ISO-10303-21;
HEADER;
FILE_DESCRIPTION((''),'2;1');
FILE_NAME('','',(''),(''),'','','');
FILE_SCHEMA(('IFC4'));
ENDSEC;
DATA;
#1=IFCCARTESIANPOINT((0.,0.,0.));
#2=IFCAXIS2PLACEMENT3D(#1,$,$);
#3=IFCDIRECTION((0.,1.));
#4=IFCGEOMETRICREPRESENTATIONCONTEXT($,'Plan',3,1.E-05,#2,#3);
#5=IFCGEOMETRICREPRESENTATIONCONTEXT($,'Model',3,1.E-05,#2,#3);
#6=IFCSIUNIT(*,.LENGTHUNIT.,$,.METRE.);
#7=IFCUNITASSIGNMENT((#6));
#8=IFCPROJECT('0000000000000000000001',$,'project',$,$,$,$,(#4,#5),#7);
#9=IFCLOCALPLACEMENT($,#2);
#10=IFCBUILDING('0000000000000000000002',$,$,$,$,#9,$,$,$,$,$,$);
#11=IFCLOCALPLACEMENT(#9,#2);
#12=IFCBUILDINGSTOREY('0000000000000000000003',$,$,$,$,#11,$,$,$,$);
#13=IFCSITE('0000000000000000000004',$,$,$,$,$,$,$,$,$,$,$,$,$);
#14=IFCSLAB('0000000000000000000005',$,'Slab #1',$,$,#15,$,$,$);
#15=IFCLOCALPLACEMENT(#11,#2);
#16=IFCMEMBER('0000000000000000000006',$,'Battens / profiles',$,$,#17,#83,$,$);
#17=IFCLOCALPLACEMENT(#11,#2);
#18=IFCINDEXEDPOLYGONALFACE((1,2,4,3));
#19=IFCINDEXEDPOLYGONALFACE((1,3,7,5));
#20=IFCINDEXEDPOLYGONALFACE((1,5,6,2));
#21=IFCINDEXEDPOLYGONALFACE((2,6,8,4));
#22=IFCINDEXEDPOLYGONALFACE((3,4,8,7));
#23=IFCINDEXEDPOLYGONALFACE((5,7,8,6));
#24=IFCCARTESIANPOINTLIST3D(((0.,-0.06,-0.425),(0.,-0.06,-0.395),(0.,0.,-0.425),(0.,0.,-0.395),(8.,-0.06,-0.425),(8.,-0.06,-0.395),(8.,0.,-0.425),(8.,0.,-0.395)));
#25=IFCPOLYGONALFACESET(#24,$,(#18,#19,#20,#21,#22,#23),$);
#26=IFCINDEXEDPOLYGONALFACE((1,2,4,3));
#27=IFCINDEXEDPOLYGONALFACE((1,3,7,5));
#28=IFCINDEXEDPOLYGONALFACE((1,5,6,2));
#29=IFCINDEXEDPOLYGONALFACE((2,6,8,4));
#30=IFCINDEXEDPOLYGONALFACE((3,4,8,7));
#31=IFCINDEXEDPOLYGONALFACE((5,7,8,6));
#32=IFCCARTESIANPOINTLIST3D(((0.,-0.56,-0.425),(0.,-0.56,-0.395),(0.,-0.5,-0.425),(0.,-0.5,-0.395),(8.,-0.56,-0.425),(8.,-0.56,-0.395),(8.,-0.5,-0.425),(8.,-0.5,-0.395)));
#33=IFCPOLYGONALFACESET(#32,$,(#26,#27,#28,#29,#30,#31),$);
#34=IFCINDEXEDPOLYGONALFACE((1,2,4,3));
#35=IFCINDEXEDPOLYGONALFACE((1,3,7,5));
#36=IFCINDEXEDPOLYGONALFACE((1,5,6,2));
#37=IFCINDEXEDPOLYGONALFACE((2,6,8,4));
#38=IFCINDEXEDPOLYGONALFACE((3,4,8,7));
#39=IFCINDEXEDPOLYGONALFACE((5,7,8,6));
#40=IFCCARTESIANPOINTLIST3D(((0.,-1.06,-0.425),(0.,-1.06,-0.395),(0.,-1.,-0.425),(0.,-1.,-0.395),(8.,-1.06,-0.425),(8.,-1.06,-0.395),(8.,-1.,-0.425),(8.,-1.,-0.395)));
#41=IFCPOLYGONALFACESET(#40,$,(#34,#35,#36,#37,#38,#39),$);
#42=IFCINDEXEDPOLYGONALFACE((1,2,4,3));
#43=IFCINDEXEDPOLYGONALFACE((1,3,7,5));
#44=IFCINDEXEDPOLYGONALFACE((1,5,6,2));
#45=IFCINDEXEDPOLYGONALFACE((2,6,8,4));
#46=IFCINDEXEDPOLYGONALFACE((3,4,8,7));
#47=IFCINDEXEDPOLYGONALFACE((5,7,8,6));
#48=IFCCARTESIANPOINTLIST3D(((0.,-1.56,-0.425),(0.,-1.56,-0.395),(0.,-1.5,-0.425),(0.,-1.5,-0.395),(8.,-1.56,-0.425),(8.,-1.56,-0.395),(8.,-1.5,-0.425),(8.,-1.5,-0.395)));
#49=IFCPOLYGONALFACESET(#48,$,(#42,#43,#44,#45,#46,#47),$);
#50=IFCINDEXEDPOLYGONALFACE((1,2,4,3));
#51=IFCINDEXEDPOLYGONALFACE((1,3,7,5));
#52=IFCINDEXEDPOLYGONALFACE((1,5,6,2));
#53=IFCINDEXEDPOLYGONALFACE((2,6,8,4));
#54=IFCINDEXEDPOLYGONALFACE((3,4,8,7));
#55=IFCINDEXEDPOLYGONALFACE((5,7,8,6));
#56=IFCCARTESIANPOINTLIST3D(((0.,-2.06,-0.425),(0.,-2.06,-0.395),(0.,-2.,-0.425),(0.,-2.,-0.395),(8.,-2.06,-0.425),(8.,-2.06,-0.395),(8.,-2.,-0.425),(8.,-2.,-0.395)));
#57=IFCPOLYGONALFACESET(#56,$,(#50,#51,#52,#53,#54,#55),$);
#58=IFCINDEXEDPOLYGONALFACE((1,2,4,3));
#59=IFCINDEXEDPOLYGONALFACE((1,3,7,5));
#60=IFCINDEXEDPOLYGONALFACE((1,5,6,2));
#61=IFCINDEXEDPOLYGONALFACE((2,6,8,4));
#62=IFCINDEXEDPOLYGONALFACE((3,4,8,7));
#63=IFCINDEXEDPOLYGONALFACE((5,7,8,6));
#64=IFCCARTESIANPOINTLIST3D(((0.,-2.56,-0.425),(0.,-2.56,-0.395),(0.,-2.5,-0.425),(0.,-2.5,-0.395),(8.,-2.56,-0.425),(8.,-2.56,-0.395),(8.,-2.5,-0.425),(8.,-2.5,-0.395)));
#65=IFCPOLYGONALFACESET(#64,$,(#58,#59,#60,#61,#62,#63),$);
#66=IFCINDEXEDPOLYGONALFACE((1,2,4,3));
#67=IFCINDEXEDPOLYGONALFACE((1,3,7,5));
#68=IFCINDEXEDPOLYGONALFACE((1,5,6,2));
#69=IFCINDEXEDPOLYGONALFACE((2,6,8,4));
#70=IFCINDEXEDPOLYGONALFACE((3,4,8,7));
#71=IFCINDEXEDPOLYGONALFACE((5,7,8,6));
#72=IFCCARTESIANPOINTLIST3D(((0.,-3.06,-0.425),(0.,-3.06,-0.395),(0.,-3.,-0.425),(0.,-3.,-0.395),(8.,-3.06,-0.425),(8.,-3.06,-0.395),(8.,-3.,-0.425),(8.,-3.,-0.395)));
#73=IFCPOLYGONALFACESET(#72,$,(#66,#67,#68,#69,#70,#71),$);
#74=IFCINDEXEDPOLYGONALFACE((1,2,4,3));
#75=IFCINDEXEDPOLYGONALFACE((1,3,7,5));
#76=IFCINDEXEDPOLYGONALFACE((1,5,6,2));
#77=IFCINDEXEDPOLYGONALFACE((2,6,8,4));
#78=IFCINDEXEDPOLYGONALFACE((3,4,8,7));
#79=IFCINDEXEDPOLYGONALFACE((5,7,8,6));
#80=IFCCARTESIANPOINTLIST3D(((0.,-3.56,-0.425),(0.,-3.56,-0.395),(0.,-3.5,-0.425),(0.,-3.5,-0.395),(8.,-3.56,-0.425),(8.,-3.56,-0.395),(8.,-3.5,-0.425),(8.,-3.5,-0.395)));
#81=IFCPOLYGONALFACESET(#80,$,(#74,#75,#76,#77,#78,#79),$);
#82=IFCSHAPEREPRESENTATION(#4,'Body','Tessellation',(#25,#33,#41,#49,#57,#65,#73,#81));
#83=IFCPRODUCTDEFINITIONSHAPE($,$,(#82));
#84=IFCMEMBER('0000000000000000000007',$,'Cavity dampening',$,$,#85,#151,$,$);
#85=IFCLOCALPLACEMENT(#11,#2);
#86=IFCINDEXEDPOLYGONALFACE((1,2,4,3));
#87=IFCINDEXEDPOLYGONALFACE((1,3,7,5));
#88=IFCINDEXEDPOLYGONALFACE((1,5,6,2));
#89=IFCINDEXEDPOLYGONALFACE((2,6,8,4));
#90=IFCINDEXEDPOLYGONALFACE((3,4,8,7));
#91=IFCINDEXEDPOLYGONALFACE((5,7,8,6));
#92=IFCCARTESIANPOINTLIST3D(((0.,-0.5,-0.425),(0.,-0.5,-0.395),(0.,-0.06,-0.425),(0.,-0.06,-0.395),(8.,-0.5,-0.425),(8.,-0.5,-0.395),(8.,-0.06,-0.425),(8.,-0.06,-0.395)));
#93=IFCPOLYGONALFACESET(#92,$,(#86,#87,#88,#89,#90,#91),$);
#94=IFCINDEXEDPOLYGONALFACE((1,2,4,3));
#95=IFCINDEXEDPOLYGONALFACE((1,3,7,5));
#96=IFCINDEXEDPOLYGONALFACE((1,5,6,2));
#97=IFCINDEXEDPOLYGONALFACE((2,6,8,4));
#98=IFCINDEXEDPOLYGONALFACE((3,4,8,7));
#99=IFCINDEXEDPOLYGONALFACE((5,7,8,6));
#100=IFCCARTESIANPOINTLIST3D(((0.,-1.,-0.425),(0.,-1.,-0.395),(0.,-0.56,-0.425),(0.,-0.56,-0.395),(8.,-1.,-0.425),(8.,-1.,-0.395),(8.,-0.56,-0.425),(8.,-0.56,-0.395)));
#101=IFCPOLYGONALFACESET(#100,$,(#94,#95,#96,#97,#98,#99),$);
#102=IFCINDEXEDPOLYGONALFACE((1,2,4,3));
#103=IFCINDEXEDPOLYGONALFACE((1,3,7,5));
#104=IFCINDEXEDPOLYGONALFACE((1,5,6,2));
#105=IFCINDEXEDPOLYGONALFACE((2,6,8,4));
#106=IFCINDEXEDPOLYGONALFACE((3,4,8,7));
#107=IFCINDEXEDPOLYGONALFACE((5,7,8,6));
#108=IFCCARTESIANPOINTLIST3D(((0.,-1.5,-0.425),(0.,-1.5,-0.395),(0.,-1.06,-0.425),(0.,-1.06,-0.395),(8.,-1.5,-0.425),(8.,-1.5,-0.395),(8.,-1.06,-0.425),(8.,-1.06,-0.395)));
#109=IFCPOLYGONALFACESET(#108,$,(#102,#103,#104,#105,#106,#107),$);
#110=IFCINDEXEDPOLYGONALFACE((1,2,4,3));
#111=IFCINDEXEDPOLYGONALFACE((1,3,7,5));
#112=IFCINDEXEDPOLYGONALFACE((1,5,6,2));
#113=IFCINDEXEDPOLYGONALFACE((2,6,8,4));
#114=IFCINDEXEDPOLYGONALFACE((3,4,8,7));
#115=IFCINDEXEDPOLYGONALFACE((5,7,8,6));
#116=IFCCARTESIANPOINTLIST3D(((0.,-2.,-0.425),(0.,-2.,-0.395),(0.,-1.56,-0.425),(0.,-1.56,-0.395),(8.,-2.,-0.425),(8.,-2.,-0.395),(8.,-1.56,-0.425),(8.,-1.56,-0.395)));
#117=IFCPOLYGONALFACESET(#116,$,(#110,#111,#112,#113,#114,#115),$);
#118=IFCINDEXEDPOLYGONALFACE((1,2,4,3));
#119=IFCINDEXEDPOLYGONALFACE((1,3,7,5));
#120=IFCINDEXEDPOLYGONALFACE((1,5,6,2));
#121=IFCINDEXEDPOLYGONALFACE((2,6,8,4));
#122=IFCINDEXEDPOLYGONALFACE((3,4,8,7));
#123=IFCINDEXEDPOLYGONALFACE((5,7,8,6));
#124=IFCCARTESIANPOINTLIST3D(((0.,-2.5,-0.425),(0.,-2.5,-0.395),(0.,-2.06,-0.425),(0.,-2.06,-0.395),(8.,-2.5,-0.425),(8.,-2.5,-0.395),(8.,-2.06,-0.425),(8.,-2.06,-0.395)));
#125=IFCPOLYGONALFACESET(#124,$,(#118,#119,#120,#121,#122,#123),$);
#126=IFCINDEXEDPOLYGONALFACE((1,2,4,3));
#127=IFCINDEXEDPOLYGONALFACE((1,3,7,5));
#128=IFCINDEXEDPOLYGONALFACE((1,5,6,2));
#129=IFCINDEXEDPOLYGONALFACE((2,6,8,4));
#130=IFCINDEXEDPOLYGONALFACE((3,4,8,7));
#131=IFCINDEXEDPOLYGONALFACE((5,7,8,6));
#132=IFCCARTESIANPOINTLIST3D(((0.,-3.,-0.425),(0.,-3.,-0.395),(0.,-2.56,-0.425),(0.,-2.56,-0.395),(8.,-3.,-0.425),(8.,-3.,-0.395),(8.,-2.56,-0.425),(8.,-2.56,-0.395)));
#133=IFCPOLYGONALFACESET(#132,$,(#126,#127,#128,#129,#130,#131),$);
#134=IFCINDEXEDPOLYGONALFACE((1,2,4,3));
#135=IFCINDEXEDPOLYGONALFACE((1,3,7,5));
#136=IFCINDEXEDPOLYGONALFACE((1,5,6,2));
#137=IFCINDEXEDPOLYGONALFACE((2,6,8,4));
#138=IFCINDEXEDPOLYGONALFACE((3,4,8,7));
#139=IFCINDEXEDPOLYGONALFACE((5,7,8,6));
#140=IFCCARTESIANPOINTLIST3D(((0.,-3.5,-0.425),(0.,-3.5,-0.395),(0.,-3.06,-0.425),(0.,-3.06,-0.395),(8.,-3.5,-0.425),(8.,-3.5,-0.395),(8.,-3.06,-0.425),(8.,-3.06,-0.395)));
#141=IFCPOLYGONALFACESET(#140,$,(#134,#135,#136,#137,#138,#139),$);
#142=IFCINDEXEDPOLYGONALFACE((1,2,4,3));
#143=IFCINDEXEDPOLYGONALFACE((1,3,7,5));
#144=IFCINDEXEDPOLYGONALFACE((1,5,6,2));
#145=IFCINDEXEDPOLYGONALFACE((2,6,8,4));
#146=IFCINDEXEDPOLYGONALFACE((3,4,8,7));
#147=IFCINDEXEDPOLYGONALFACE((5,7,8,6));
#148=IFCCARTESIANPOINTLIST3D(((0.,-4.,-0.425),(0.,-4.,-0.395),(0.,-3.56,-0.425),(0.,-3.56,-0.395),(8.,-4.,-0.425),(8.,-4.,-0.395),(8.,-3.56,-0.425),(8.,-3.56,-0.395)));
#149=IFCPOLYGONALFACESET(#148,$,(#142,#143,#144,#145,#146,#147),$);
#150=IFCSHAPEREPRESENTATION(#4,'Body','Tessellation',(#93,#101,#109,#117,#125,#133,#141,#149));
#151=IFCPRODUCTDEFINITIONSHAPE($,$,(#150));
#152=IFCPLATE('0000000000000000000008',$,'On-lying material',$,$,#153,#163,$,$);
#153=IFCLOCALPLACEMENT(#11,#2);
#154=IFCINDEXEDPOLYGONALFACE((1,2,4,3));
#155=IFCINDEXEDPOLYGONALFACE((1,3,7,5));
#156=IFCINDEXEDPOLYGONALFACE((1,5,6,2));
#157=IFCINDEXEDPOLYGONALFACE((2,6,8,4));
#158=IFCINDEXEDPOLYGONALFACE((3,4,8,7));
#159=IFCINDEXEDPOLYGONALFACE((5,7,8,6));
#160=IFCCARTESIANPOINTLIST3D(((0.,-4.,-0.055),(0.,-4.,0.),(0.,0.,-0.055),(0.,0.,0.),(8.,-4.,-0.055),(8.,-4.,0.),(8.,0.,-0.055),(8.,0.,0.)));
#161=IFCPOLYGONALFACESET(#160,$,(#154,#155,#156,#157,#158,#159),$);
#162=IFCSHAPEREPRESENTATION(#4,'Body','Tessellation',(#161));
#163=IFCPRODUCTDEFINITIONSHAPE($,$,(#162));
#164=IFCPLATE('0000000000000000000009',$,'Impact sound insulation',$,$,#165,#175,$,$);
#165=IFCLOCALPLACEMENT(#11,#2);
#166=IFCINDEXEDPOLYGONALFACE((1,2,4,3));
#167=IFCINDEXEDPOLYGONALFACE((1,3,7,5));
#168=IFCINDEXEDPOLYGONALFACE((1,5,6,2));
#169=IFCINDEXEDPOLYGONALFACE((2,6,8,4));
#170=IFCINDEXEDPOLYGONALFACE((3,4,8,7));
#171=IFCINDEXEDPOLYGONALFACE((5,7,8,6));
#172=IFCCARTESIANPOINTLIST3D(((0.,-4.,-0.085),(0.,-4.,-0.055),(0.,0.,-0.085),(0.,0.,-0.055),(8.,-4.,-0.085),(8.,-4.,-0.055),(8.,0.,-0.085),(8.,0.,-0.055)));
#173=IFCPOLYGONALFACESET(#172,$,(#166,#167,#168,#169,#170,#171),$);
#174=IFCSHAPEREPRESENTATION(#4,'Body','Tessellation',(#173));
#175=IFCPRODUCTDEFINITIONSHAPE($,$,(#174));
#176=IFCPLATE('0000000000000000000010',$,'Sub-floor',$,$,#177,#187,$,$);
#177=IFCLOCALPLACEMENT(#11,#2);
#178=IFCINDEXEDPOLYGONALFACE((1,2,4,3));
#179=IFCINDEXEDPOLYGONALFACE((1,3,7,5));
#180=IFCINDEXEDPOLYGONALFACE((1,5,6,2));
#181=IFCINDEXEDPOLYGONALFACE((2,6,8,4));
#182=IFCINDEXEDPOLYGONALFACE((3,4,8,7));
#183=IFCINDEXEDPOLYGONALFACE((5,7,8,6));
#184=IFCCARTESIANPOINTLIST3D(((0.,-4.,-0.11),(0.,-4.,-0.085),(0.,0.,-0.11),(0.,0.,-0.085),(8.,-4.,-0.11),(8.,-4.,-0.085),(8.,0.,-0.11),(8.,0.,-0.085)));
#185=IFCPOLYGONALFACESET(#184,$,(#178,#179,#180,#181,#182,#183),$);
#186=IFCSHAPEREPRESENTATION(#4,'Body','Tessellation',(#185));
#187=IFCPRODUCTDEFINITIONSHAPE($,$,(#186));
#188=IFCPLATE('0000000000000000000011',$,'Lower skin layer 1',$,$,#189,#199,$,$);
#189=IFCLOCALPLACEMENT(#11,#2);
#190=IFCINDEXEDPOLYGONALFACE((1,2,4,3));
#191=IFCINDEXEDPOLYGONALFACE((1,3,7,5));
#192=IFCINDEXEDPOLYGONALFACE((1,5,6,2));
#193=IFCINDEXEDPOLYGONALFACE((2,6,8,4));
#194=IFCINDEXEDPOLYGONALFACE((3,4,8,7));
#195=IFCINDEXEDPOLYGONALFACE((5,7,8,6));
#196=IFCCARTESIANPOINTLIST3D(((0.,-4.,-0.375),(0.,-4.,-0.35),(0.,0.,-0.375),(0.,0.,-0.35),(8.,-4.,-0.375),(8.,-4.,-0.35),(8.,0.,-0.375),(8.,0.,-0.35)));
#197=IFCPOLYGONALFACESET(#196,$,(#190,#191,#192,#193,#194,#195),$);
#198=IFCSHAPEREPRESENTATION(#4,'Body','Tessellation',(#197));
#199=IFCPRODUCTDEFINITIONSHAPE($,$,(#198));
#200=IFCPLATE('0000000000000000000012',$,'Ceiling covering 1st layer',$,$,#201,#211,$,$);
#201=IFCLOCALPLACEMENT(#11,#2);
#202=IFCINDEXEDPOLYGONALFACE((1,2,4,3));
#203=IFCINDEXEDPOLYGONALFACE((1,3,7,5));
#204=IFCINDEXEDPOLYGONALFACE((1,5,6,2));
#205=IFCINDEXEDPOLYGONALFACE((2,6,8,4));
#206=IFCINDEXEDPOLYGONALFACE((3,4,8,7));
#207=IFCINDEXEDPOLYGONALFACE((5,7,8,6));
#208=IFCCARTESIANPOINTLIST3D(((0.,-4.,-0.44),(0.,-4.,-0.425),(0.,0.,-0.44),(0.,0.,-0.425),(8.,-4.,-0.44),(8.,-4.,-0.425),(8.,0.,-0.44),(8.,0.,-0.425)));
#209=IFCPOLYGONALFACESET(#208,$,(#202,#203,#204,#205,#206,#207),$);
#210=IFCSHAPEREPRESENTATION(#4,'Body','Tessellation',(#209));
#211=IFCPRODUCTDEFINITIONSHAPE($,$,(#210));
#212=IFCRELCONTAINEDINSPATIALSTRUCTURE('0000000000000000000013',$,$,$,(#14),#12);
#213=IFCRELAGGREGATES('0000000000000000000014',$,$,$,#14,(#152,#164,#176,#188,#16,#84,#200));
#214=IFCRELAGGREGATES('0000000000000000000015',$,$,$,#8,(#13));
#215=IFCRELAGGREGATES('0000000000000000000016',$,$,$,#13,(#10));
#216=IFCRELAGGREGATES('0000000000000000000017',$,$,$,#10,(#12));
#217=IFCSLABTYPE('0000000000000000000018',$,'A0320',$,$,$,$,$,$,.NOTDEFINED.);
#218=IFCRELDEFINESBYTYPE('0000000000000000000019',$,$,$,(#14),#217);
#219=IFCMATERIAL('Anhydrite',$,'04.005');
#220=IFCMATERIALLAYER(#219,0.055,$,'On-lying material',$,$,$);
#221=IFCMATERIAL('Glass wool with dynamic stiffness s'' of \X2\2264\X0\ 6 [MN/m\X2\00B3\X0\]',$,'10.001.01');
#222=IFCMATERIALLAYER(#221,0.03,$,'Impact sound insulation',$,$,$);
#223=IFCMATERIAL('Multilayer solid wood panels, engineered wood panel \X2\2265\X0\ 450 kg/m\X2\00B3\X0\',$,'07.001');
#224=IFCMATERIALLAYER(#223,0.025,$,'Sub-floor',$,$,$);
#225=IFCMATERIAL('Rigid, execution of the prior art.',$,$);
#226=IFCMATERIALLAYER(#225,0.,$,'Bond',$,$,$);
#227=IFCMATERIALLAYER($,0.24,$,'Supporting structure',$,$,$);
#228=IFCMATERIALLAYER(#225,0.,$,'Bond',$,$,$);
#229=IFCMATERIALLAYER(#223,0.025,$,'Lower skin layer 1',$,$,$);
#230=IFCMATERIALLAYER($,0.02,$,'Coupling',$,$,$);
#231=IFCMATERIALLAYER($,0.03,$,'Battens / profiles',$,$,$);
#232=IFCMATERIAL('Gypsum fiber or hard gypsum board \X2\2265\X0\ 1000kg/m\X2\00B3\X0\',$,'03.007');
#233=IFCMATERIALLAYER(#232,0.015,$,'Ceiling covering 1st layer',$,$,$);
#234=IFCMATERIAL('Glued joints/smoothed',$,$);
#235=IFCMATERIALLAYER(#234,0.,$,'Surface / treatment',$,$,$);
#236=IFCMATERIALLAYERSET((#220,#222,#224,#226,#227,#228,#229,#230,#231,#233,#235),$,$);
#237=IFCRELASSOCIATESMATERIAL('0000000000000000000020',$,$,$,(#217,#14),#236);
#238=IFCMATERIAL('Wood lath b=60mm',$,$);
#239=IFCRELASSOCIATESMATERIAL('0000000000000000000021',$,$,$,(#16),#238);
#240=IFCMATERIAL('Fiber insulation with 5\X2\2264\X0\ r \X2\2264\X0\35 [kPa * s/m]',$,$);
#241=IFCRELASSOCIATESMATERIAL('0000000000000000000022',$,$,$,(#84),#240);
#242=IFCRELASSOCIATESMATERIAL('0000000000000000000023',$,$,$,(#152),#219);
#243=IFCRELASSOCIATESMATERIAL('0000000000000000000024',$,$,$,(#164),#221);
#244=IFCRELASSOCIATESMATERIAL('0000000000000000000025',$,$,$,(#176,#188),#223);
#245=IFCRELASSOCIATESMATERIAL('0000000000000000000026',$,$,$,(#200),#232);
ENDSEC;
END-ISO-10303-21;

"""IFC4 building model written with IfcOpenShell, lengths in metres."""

from ifc_helpers import new_model, si_unit, direction, frame, frame_2d, origin, origin_with_axes, place, context, project, spatial, rectangle, extrude, material, layer, layer_set, type_object, element, aggregate, save


model = new_model("IFC4")

# Units and contexts
plan_context = context("Plan", 3, precision=1e-05, world=origin(), true_north=direction((0.0, 1.0)))
model_context = context("Model", 3, precision=1e-05, world=origin(), true_north=direction((0.0, 1.0)))
ifc_project = project(units=[si_unit("LENGTHUNIT", "METRE")], contexts=[plan_context, model_context])

# Site, building, storey
site = spatial("IfcSite", under=ifc_project)
building_placement = place(None, origin())
building = spatial("IfcBuilding", under=site, at=building_placement)
storey_placement = place(building_placement, origin())
storey = spatial("IfcBuildingStorey", under=building, at=storey_placement)

# Slab, members, plates
ifc_material_1 = material(Name="Anhydrite", Category="04.005")
ifc_layer_1 = layer(ifc_material_1, 0.055, Name="On-lying material")
ifc_material_2 = material(Name="Glass wool with dynamic stiffness s' of ≤ 6 [MN/m³]", Category="10.001.01")
ifc_layer_2 = layer(ifc_material_2, 0.03, Name="Impact sound insulation")
ifc_material_3 = material(Name="Multilayer solid wood panels, engineered wood panel ≥ 450 kg/m³", Category="07.001")
ifc_layer_3 = layer(ifc_material_3, 0.025, Name="Sub-floor")
ifc_material_4 = material(Name="Rigid, execution of the prior art.")
ifc_layer_4 = layer(ifc_material_4, 0.0, Name="Bond")
ifc_layer_5 = layer(None, 0.24, Name="Supporting structure")
ifc_layer_6 = layer(ifc_material_4, 0.0, Name="Bond")
ifc_layer_7 = layer(ifc_material_3, 0.025, Name="Lower skin layer 1")
ifc_layer_8 = layer(None, 0.02, Name="Coupling")
ifc_layer_9 = layer(None, 0.03, Name="Battens / profiles")
ifc_material_5 = material(Name="Gypsum fiber or hard gypsum board ≥ 1000kg/m³", Category="03.007")
ifc_layer_10 = layer(ifc_material_5, 0.015, Name="Ceiling covering 1st layer")
ifc_material_6 = material(Name="Glued joints/smoothed")
ifc_layer_11 = layer(ifc_material_6, 0.0, Name="Surface / treatment")
ifc_layer_set = layer_set([ifc_layer_1, ifc_layer_2, ifc_layer_3, ifc_layer_4, ifc_layer_5, ifc_layer_6, ifc_layer_7, ifc_layer_8, ifc_layer_9, ifc_layer_10, ifc_layer_11])
slab_type = type_object("IfcSlabType", Name="A0320", PredefinedType="NOTDEFINED", material=ifc_layer_set)
slab_placement = place(None, frame((0.0, 0.0, 0.0), z_axis=(0.0, 0.0, -1.0), x_axis=(1.0, 0.0, 0.0)))
slab = element("IfcSlab", 1, at=slab_placement, inside=storey, type_object=slab_type, material=ifc_layer_set, Name="Slab #1")
ifc_material_7 = material(Name="Fiber insulation with 5≤ r ≤35 [kPa * s/m]")
ifc_material_8 = material(Name="Wood lath b=60mm")
member_1_placement = place(slab_placement, origin())
member_1 = element("IfcMember", 2, at=member_1_placement, material=ifc_material_8, Name="Battens / profiles", context=plan_context, shape_type="SweptSolid", body=[
    extrude(rectangle(XDim=0.06, YDim=0.03, at=frame_2d((0.03, 0.015), x_axis=(1.0, 0.0))), frame((0.0, 0.0, 0.395), z_axis=(1.0, 0.0, 0.0), x_axis=(0.0, 1.0, 0.0)), (0.0, 0.0, 1.0), 8.0),
    extrude(rectangle(XDim=0.06, YDim=0.03, at=frame_2d((0.03, 0.015), x_axis=(1.0, 0.0))), frame((0.0, 0.5, 0.395), z_axis=(1.0, 0.0, 0.0), x_axis=(0.0, 1.0, 0.0)), (0.0, 0.0, 1.0), 8.0),
    extrude(rectangle(XDim=0.06, YDim=0.03, at=frame_2d((0.03, 0.015), x_axis=(1.0, 0.0))), frame((0.0, 1.0, 0.395), z_axis=(1.0, 0.0, 0.0), x_axis=(0.0, 1.0, 0.0)), (0.0, 0.0, 1.0), 8.0),
    extrude(rectangle(XDim=0.06, YDim=0.03, at=frame_2d((0.03, 0.015), x_axis=(1.0, 0.0))), frame((0.0, 1.5, 0.395), z_axis=(1.0, 0.0, 0.0), x_axis=(0.0, 1.0, 0.0)), (0.0, 0.0, 1.0), 8.0),
    extrude(rectangle(XDim=0.06, YDim=0.03, at=frame_2d((0.03, 0.015), x_axis=(1.0, 0.0))), frame((0.0, 2.0, 0.395), z_axis=(1.0, 0.0, 0.0), x_axis=(0.0, 1.0, 0.0)), (0.0, 0.0, 1.0), 8.0),
    extrude(rectangle(XDim=0.06, YDim=0.03, at=frame_2d((0.03, 0.015), x_axis=(1.0, 0.0))), frame((0.0, 2.5, 0.395), z_axis=(1.0, 0.0, 0.0), x_axis=(0.0, 1.0, 0.0)), (0.0, 0.0, 1.0), 8.0),
    extrude(rectangle(XDim=0.06, YDim=0.03, at=frame_2d((0.03, 0.015), x_axis=(1.0, 0.0))), frame((0.0, 3.0, 0.395), z_axis=(1.0, 0.0, 0.0), x_axis=(0.0, 1.0, 0.0)), (0.0, 0.0, 1.0), 8.0),
    extrude(rectangle(XDim=0.06, YDim=0.03, at=frame_2d((0.03, 0.015), x_axis=(1.0, 0.0))), frame((0.0, 3.5, 0.395), z_axis=(1.0, 0.0, 0.0), x_axis=(0.0, 1.0, 0.0)), (0.0, 0.0, 1.0), 8.0),
])
member_2_placement = place(slab_placement, origin())
member_2 = element("IfcMember", 3, at=member_2_placement, material=ifc_material_7, Name="Cavity dampening", context=plan_context, shape_type="SweptSolid", body=[
    extrude(rectangle(XDim=0.44, YDim=0.03, at=frame_2d((0.22, 0.015), x_axis=(1.0, 0.0))), frame((0.0, 0.06, 0.395), z_axis=(1.0, 0.0, 0.0), x_axis=(0.0, 1.0, 0.0)), (0.0, 0.0, 1.0), 8.0),
    extrude(rectangle(XDim=0.44, YDim=0.03, at=frame_2d((0.22, 0.015), x_axis=(1.0, 0.0))), frame((0.0, 0.56, 0.395), z_axis=(1.0, 0.0, 0.0), x_axis=(0.0, 1.0, 0.0)), (0.0, 0.0, 1.0), 8.0),
    extrude(rectangle(XDim=0.44, YDim=0.03, at=frame_2d((0.22, 0.015), x_axis=(1.0, 0.0))), frame((0.0, 1.06, 0.395), z_axis=(1.0, 0.0, 0.0), x_axis=(0.0, 1.0, 0.0)), (0.0, 0.0, 1.0), 8.0),
    extrude(rectangle(XDim=0.44, YDim=0.03, at=frame_2d((0.22, 0.015), x_axis=(1.0, 0.0))), frame((0.0, 1.56, 0.395), z_axis=(1.0, 0.0, 0.0), x_axis=(0.0, 1.0, 0.0)), (0.0, 0.0, 1.0), 8.0),
    extrude(rectangle(XDim=0.44, YDim=0.03, at=frame_2d((0.22, 0.015), x_axis=(1.0, 0.0))), frame((0.0, 2.06, 0.395), z_axis=(1.0, 0.0, 0.0), x_axis=(0.0, 1.0, 0.0)), (0.0, 0.0, 1.0), 8.0),
    extrude(rectangle(XDim=0.44, YDim=0.03, at=frame_2d((0.22, 0.015), x_axis=(1.0, 0.0))), frame((0.0, 2.56, 0.395), z_axis=(1.0, 0.0, 0.0), x_axis=(0.0, 1.0, 0.0)), (0.0, 0.0, 1.0), 8.0),
    extrude(rectangle(XDim=0.44, YDim=0.03, at=frame_2d((0.22, 0.015), x_axis=(1.0, 0.0))), frame((0.0, 3.06, 0.395), z_axis=(1.0, 0.0, 0.0), x_axis=(0.0, 1.0, 0.0)), (0.0, 0.0, 1.0), 8.0),
    extrude(rectangle(XDim=0.44, YDim=0.03, at=frame_2d((0.22, 0.015), x_axis=(1.0, 0.0))), frame((0.0, 3.56, 0.395), z_axis=(1.0, 0.0, 0.0), x_axis=(0.0, 1.0, 0.0)), (0.0, 0.0, 1.0), 8.0),
])
plate_1_placement = place(slab_placement, origin())
plate_1 = element("IfcPlate", 4, at=plate_1_placement, material=ifc_material_1, Name="On-lying material", context=plan_context, shape_type="SweptSolid", body=[
    extrude(rectangle(XDim=8.0, YDim=4.0, at=frame_2d((4.0, 2.0), x_axis=(1.0, 0.0))), origin_with_axes(), (0.0, 0.0, 1.0), 0.055),
])
plate_2_placement = place(slab_placement, origin())
plate_2 = element("IfcPlate", 5, at=plate_2_placement, material=ifc_material_2, Name="Impact sound insulation", context=plan_context, shape_type="SweptSolid", body=[
    extrude(rectangle(XDim=8.0, YDim=4.0, at=frame_2d((4.0, 2.0), x_axis=(1.0, 0.0))), frame((0.0, 0.0, 0.055), z_axis=(0.0, 0.0, 1.0), x_axis=(1.0, 0.0, 0.0)), (0.0, 0.0, 1.0), 0.03),
])
plate_3_placement = place(slab_placement, origin())
plate_3 = element("IfcPlate", 6, at=plate_3_placement, material=ifc_material_3, Name="Sub-floor", context=plan_context, shape_type="SweptSolid", body=[
    extrude(rectangle(XDim=8.0, YDim=4.0, at=frame_2d((4.0, 2.0), x_axis=(1.0, 0.0))), frame((0.0, 0.0, 0.085), z_axis=(0.0, 0.0, 1.0), x_axis=(1.0, 0.0, 0.0)), (0.0, 0.0, 1.0), 0.025),
])
plate_4_placement = place(slab_placement, origin())
plate_4 = element("IfcPlate", 7, at=plate_4_placement, material=ifc_material_3, Name="Lower skin layer 1", context=plan_context, shape_type="SweptSolid", body=[
    extrude(rectangle(XDim=8.0, YDim=4.0, at=frame_2d((4.0, 2.0), x_axis=(1.0, 0.0))), frame((0.0, 0.0, 0.35), z_axis=(0.0, 0.0, 1.0), x_axis=(1.0, 0.0, 0.0)), (0.0, 0.0, 1.0), 0.025),
])
plate_5_placement = place(slab_placement, origin())
plate_5 = element("IfcPlate", 8, at=plate_5_placement, material=ifc_material_5, Name="Ceiling covering 1st layer", context=plan_context, shape_type="SweptSolid", body=[
    extrude(rectangle(XDim=8.0, YDim=4.0, at=frame_2d((4.0, 2.0), x_axis=(1.0, 0.0))), frame((0.0, 0.0, 0.425), z_axis=(0.0, 0.0, 1.0), x_axis=(1.0, 0.0, 0.0)), (0.0, 0.0, 1.0), 0.015),
])
aggregate(slab, [plate_1, plate_2, plate_3, plate_4, member_1, member_2, plate_5])

save(model, "model.ifc")
